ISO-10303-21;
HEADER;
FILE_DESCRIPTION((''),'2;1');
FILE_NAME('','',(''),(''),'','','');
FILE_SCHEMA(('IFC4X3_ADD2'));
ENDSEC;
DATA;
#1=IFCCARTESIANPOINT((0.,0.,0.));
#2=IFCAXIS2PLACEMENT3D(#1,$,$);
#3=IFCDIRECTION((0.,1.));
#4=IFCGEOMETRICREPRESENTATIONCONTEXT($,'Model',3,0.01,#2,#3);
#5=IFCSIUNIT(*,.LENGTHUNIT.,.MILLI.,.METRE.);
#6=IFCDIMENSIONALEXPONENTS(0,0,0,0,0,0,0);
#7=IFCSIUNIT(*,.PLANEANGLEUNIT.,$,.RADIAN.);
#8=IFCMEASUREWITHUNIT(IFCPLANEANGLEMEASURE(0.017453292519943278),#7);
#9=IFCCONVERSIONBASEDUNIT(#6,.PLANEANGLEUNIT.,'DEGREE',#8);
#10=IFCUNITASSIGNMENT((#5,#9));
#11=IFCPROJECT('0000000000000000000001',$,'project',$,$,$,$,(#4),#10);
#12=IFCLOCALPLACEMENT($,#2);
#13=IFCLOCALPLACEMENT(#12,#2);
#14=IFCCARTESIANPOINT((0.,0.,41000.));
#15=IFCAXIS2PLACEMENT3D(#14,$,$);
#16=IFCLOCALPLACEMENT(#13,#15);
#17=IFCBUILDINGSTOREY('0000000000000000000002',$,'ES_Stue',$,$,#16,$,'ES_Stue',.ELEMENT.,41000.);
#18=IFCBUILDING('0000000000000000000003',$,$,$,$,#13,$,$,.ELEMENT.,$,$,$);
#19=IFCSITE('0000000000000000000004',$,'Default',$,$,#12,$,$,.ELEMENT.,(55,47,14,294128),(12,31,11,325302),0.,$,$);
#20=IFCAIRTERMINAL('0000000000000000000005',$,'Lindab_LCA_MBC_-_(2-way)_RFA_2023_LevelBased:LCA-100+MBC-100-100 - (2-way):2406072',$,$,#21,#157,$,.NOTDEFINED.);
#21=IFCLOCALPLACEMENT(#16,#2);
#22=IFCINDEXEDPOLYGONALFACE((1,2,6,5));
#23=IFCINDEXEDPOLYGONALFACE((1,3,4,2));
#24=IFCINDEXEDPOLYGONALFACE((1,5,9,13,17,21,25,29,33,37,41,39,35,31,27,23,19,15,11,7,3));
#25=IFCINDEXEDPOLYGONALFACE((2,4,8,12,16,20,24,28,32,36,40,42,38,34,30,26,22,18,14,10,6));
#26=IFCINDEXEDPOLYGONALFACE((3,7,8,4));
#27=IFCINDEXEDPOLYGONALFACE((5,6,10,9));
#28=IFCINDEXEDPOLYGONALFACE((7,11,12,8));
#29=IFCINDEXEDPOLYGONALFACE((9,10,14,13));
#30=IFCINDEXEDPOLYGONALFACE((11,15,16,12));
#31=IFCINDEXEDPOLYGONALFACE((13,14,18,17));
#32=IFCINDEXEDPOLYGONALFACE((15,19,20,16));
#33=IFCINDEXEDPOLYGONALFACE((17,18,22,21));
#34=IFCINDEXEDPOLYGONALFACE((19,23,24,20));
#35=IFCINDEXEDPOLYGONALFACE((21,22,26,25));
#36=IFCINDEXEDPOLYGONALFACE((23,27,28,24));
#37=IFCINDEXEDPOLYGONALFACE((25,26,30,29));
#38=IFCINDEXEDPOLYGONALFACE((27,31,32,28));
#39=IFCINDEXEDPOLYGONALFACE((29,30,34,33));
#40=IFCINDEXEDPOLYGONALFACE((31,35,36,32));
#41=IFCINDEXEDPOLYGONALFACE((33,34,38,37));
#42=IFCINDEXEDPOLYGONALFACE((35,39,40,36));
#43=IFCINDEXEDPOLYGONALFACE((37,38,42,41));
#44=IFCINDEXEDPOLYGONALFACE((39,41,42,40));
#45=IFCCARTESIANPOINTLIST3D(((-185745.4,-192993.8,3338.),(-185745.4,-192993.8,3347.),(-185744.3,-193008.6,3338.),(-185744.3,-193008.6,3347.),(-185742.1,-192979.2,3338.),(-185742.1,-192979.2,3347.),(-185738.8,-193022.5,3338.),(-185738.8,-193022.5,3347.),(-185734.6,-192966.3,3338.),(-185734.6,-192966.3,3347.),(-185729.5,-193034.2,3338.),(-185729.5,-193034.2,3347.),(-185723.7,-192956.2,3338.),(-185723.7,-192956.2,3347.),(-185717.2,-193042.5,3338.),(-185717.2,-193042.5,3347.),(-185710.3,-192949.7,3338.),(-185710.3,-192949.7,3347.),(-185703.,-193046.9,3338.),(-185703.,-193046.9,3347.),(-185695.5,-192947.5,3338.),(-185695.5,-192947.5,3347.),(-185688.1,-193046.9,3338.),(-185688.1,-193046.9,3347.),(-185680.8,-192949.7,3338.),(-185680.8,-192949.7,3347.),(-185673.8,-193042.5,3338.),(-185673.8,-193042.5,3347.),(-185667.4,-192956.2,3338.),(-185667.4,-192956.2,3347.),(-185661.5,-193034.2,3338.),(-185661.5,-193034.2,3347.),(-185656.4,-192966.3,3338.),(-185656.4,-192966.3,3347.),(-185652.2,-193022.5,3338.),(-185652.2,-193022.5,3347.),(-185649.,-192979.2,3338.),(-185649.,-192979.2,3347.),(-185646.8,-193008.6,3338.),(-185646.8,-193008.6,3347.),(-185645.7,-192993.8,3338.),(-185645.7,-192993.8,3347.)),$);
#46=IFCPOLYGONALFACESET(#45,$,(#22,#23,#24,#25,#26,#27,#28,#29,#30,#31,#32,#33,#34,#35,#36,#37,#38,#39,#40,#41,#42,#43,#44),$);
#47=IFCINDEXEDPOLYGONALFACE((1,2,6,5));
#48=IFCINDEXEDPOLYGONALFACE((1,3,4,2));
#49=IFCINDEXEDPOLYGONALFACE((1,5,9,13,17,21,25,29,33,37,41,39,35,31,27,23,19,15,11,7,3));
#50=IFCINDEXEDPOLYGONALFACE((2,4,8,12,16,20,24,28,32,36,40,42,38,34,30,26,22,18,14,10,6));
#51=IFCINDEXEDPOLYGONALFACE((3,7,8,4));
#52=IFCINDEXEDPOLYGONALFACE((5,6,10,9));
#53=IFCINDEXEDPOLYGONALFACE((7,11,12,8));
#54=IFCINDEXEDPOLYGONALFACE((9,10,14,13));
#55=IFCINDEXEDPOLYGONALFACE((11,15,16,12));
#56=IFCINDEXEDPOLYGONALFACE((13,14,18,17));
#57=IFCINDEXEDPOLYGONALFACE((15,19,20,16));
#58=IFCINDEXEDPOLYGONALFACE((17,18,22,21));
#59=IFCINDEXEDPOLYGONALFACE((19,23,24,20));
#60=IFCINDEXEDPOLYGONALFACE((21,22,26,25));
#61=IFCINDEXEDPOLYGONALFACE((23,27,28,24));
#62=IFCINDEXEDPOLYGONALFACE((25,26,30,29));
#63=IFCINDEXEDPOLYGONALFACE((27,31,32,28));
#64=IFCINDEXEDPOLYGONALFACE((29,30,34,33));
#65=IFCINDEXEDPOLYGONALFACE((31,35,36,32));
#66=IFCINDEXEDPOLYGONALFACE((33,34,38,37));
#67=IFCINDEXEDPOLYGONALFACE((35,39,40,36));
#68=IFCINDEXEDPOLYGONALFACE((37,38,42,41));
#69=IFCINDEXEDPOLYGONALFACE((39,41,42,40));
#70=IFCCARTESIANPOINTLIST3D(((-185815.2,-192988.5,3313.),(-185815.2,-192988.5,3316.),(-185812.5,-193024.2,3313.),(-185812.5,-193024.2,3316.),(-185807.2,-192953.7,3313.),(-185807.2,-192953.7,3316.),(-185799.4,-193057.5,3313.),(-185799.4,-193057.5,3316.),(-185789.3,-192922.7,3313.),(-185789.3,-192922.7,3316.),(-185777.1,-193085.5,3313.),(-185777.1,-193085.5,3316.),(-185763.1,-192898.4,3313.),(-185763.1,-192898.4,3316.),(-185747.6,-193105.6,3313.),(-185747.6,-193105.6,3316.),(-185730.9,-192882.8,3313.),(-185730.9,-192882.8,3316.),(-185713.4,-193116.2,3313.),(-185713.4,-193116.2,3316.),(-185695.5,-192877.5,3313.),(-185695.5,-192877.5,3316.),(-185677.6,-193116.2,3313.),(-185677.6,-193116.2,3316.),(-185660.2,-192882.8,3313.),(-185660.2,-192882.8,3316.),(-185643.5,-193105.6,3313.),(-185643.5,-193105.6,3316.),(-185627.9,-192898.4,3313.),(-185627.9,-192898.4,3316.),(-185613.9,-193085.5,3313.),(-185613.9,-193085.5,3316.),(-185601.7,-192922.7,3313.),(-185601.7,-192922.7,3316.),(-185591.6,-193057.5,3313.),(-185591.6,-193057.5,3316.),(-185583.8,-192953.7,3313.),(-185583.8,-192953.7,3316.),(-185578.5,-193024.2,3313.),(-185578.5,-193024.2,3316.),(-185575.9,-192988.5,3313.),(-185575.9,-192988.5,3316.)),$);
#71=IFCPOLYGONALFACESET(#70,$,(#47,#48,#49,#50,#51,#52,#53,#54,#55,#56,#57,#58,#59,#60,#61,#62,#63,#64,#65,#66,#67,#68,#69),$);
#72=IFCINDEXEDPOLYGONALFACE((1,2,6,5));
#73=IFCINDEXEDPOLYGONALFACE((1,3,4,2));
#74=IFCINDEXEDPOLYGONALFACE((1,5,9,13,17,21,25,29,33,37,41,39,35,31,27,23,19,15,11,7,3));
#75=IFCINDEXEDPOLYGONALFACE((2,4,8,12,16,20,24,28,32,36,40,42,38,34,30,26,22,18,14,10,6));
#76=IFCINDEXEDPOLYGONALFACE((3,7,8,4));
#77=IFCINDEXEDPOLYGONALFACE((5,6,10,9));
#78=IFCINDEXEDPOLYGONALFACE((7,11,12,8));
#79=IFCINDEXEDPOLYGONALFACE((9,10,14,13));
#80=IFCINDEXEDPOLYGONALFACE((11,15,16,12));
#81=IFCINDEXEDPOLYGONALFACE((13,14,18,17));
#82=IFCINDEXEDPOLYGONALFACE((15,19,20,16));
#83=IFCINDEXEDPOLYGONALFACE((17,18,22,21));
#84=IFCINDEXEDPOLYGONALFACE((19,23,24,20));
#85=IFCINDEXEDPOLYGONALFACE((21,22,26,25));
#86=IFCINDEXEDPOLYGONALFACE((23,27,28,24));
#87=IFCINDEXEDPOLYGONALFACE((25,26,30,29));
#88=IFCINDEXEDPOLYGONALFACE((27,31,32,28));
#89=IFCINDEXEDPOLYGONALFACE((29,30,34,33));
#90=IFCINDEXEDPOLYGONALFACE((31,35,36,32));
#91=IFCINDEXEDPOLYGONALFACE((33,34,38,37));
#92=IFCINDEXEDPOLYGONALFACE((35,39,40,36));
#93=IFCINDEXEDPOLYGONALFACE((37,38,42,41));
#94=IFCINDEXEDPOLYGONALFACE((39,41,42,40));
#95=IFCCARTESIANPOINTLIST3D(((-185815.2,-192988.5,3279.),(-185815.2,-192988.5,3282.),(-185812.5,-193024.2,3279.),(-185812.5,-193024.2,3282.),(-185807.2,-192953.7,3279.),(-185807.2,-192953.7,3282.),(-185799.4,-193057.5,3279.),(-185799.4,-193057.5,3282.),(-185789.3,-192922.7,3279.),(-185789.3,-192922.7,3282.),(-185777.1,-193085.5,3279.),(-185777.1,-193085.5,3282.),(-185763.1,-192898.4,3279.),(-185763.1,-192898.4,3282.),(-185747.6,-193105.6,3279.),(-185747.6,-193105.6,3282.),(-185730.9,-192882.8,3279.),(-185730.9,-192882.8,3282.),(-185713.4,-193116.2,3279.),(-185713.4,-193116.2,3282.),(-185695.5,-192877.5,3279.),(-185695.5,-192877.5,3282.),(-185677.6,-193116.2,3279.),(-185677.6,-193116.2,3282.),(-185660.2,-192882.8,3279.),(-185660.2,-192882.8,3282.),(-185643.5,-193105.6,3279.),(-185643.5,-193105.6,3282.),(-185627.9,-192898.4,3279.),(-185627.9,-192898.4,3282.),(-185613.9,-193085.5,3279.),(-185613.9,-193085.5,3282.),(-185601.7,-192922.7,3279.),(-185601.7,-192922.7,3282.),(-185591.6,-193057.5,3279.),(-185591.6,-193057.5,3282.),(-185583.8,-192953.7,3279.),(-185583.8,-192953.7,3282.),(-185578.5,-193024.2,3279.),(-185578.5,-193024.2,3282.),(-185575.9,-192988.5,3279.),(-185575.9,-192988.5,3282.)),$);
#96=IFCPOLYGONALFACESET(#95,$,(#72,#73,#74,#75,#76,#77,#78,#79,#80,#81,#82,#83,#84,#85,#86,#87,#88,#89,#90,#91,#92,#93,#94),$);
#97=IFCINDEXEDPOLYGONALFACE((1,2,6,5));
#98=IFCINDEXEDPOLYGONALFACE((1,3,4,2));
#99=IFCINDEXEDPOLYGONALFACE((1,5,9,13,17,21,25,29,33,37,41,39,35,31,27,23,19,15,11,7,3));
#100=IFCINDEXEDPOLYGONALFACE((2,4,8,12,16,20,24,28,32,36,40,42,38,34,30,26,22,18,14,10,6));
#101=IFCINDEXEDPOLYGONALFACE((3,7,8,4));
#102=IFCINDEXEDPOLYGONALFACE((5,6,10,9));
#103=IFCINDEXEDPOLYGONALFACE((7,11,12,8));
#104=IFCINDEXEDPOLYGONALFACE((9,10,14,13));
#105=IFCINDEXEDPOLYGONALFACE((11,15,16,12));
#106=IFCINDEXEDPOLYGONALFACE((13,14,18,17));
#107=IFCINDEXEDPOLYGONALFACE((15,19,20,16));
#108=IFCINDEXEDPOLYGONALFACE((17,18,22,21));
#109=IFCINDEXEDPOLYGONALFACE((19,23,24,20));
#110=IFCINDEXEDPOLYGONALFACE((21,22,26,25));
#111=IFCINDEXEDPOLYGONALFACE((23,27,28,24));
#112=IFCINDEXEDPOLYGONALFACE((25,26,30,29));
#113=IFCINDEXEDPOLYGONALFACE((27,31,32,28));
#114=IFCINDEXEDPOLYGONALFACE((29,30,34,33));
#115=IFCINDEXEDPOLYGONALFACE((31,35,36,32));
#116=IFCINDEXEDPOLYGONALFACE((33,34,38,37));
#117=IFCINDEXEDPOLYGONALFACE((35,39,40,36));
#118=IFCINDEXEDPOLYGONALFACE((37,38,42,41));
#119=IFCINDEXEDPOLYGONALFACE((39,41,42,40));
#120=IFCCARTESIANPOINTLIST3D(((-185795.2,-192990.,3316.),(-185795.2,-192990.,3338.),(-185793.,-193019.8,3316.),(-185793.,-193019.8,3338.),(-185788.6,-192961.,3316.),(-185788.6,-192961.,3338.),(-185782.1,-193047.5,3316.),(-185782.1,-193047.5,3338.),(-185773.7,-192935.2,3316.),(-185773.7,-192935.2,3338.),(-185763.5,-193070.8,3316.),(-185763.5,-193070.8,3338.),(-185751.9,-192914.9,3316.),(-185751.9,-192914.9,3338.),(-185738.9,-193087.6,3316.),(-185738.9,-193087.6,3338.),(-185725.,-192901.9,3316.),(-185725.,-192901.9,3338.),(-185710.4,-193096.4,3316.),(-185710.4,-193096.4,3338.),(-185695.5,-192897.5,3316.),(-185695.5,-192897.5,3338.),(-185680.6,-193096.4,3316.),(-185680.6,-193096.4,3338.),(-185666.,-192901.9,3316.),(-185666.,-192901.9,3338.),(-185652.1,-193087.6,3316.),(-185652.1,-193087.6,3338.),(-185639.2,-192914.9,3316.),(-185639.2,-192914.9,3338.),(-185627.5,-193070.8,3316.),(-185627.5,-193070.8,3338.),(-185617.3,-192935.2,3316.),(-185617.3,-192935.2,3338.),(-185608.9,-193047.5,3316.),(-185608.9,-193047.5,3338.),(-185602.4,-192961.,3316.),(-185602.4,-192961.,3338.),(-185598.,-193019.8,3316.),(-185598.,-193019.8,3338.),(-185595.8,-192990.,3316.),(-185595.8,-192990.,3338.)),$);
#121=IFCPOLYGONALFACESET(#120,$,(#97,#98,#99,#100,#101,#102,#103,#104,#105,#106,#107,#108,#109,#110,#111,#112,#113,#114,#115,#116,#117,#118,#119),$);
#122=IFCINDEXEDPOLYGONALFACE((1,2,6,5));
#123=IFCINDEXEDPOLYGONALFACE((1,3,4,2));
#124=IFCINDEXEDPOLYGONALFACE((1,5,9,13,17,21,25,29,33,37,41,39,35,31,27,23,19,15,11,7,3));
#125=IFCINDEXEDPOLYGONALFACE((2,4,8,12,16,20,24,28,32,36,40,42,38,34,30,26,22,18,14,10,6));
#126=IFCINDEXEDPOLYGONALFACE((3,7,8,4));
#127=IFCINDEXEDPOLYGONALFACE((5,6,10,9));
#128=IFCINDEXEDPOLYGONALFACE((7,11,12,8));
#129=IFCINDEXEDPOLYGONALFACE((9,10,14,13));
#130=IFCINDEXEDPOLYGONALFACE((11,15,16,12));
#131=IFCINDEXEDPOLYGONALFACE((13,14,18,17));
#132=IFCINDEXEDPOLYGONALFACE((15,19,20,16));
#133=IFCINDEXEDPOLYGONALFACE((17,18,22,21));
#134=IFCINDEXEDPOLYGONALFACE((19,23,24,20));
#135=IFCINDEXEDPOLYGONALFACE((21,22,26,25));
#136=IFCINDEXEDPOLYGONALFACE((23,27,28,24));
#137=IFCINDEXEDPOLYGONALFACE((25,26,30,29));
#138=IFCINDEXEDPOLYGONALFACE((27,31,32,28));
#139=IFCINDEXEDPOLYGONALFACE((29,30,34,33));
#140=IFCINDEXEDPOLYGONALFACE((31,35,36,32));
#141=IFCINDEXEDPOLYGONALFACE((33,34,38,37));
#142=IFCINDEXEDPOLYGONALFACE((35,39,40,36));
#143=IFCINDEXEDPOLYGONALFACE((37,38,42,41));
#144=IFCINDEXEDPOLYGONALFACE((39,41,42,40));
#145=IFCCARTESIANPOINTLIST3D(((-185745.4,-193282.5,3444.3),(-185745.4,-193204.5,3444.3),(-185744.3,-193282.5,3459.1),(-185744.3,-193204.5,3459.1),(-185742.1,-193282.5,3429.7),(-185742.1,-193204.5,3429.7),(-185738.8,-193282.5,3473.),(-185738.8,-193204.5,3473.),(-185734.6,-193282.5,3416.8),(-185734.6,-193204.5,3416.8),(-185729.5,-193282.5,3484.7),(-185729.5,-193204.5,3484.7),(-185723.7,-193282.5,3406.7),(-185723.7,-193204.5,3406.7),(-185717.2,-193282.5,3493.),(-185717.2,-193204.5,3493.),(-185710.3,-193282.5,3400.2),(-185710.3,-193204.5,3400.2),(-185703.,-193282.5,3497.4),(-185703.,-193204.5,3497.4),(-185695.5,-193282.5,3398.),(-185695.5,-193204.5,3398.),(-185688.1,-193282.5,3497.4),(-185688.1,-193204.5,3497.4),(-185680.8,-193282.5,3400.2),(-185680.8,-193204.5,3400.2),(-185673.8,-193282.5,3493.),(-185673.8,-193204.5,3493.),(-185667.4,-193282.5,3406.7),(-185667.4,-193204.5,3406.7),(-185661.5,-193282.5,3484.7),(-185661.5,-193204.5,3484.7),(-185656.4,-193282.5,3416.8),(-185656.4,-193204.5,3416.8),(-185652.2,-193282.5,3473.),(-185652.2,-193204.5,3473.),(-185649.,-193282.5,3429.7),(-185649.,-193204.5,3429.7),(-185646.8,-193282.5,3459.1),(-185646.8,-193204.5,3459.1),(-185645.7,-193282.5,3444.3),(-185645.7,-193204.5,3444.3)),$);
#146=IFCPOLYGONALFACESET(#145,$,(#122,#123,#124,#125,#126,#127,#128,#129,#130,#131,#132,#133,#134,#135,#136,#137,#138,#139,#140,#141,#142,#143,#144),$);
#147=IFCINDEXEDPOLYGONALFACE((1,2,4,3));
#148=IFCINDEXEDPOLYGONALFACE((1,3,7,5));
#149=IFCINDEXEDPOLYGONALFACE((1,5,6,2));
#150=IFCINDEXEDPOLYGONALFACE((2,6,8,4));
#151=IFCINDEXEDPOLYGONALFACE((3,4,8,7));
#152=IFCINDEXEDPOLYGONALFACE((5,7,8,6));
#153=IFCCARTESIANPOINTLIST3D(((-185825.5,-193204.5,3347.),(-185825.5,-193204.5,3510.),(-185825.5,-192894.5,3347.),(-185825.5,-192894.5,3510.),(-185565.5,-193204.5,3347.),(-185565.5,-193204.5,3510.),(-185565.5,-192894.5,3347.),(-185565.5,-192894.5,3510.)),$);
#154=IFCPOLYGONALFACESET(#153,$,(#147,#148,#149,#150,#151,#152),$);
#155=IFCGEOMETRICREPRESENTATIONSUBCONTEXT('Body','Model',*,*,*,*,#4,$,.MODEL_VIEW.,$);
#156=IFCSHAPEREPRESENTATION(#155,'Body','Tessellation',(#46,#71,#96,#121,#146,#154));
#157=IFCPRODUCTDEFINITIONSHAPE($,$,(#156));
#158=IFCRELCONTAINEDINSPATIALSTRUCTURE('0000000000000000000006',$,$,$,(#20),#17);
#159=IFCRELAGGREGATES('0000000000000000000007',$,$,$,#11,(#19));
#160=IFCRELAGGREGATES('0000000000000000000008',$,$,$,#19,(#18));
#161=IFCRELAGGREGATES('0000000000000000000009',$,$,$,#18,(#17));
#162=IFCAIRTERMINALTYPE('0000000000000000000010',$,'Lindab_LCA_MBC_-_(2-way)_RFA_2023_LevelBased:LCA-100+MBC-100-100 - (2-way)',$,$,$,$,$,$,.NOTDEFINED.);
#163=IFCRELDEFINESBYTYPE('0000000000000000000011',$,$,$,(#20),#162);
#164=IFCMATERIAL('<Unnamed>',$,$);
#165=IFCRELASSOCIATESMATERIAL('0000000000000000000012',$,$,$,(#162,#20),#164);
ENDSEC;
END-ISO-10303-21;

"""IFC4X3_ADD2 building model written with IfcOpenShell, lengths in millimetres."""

from ifc_helpers import new_model, entity, si_unit, converted_unit, direction, frame, frame_2d, origin, origin_2d_with_axis, place, context, subcontext, project, spatial, rectangle, circle, extrude, source, transform, mapped, material, type_object, type_shapes, element, save


model = new_model("IFC4X3_ADD2")

# Units and contexts
model_context = context("Model", 3, precision=0.01, world=origin(), true_north=direction((0.0, 1.0)))
body_context = subcontext(model_context, "Body", "Model", "MODEL_VIEW")
ifc_project = project(units=[si_unit("LENGTHUNIT", "METRE", prefix="MILLI"), converted_unit("PLANEANGLEUNIT", "DEGREE", entity("IfcPlaneAngleMeasure", 0.017453292519943278), si_unit("PLANEANGLEUNIT", "RADIAN"), dimensions=[0, 0, 0, 0, 0, 0, 0])], contexts=[model_context])

# Site, building, storey
site_placement = place(None, origin())
site = spatial("IfcSite", under=ifc_project, at=site_placement, Name="Default", CompositionType="ELEMENT", RefLatitude=(55, 47, 14, 294128), RefLongitude=(12, 31, 11, 325302), RefElevation=0.0)
building_placement = place(site_placement, origin())
building = spatial("IfcBuilding", under=site, at=building_placement, CompositionType="ELEMENT")
storey_placement = place(building_placement, frame((0.0, 0.0, 41000.0)))
storey = spatial("IfcBuildingStorey", under=building, at=storey_placement, Name="ES_Stue", LongName="ES_Stue", CompositionType="ELEMENT", Elevation=41000.0)

# Air terminal
ifc_material_1 = material(Name="<Unnamed>")
air_terminal_type = type_object("IfcAirTerminalType", Name="Lindab_LCA_MBC_-_(2-way)_RFA_2023_LevelBased:LCA-100+MBC-100-100 - (2-way)", PredefinedType="NOTDEFINED", material=ifc_material_1)
shared_shape_1 = source(origin(), body_context, "Body", "SweptSolid", [
    extrude(circle(Radius=50.0, at=frame_2d((0.0, 0.0), x_axis=(1.0, 0.0))), frame((0.0, 0.0, 22.0)), (0.0, 0.0, 1.0), 9.0),
    extrude(circle(Radius=120.0, at=frame_2d((0.0, 0.0), x_axis=(1.0, 0.0))), frame((0.0, 0.0, -3.0)), (0.0, 0.0, 1.0), 3.0),
    extrude(circle(Radius=120.0, at=frame_2d((0.0, 0.0), x_axis=(1.0, 0.0))), frame((0.0, 0.0, -37.0)), (0.0, 0.0, 1.0), 3.0),
    extrude(circle(Radius=100.0, at=frame_2d((0.0, 0.0), x_axis=(1.0, 0.0))), origin(), (0.0, 0.0, 1.0), 22.0),
    extrude(circle(Radius=50.0, at=frame_2d((0.0, 0.0), x_axis=(1.0, 0.0))), frame((-285.0, 0.0, 132.0), z_axis=(1.0, 0.0, 0.0), x_axis=(0.0, 0.0, -1.0)), (0.0, 0.0, 1.0), 78.0),
    extrude(rectangle(XDim=260.0, YDim=310.0, at=origin_2d_with_axis()), frame((-52.0, 0.0, 31.0), z_axis=(0.0, 0.0, 1.0), x_axis=(0.0, -1.0, 0.0)), (0.0, 0.0, 1.0), 163.0),
])
type_shapes(air_terminal_type, [shared_shape_1])
for number, where, z_axis, x_axis, name in (
    (1, (-185695.5, -192997.5, 3316.0), (0.0, 0.0, 1.0), (0.0, 1.0, 0.0), "Lindab_LCA_MBC_-_(2-way)_RFA_2023_LevelBased:LCA-100+MBC-100-100 - (2-way):2406072"),
):
    element("IfcAirTerminal", number, at=place(storey_placement, frame(where, z_axis=z_axis, x_axis=x_axis)), inside=storey, type_object=air_terminal_type, material=ifc_material_1, Name=name, PredefinedType="NOTDEFINED", context=body_context, shape_type="MappedRepresentation", body=[
        mapped(shared_shape_1, transform((0.0, 0.0, 0.0), scale=1.0)),
    ])

save(model, "model.ifc")
